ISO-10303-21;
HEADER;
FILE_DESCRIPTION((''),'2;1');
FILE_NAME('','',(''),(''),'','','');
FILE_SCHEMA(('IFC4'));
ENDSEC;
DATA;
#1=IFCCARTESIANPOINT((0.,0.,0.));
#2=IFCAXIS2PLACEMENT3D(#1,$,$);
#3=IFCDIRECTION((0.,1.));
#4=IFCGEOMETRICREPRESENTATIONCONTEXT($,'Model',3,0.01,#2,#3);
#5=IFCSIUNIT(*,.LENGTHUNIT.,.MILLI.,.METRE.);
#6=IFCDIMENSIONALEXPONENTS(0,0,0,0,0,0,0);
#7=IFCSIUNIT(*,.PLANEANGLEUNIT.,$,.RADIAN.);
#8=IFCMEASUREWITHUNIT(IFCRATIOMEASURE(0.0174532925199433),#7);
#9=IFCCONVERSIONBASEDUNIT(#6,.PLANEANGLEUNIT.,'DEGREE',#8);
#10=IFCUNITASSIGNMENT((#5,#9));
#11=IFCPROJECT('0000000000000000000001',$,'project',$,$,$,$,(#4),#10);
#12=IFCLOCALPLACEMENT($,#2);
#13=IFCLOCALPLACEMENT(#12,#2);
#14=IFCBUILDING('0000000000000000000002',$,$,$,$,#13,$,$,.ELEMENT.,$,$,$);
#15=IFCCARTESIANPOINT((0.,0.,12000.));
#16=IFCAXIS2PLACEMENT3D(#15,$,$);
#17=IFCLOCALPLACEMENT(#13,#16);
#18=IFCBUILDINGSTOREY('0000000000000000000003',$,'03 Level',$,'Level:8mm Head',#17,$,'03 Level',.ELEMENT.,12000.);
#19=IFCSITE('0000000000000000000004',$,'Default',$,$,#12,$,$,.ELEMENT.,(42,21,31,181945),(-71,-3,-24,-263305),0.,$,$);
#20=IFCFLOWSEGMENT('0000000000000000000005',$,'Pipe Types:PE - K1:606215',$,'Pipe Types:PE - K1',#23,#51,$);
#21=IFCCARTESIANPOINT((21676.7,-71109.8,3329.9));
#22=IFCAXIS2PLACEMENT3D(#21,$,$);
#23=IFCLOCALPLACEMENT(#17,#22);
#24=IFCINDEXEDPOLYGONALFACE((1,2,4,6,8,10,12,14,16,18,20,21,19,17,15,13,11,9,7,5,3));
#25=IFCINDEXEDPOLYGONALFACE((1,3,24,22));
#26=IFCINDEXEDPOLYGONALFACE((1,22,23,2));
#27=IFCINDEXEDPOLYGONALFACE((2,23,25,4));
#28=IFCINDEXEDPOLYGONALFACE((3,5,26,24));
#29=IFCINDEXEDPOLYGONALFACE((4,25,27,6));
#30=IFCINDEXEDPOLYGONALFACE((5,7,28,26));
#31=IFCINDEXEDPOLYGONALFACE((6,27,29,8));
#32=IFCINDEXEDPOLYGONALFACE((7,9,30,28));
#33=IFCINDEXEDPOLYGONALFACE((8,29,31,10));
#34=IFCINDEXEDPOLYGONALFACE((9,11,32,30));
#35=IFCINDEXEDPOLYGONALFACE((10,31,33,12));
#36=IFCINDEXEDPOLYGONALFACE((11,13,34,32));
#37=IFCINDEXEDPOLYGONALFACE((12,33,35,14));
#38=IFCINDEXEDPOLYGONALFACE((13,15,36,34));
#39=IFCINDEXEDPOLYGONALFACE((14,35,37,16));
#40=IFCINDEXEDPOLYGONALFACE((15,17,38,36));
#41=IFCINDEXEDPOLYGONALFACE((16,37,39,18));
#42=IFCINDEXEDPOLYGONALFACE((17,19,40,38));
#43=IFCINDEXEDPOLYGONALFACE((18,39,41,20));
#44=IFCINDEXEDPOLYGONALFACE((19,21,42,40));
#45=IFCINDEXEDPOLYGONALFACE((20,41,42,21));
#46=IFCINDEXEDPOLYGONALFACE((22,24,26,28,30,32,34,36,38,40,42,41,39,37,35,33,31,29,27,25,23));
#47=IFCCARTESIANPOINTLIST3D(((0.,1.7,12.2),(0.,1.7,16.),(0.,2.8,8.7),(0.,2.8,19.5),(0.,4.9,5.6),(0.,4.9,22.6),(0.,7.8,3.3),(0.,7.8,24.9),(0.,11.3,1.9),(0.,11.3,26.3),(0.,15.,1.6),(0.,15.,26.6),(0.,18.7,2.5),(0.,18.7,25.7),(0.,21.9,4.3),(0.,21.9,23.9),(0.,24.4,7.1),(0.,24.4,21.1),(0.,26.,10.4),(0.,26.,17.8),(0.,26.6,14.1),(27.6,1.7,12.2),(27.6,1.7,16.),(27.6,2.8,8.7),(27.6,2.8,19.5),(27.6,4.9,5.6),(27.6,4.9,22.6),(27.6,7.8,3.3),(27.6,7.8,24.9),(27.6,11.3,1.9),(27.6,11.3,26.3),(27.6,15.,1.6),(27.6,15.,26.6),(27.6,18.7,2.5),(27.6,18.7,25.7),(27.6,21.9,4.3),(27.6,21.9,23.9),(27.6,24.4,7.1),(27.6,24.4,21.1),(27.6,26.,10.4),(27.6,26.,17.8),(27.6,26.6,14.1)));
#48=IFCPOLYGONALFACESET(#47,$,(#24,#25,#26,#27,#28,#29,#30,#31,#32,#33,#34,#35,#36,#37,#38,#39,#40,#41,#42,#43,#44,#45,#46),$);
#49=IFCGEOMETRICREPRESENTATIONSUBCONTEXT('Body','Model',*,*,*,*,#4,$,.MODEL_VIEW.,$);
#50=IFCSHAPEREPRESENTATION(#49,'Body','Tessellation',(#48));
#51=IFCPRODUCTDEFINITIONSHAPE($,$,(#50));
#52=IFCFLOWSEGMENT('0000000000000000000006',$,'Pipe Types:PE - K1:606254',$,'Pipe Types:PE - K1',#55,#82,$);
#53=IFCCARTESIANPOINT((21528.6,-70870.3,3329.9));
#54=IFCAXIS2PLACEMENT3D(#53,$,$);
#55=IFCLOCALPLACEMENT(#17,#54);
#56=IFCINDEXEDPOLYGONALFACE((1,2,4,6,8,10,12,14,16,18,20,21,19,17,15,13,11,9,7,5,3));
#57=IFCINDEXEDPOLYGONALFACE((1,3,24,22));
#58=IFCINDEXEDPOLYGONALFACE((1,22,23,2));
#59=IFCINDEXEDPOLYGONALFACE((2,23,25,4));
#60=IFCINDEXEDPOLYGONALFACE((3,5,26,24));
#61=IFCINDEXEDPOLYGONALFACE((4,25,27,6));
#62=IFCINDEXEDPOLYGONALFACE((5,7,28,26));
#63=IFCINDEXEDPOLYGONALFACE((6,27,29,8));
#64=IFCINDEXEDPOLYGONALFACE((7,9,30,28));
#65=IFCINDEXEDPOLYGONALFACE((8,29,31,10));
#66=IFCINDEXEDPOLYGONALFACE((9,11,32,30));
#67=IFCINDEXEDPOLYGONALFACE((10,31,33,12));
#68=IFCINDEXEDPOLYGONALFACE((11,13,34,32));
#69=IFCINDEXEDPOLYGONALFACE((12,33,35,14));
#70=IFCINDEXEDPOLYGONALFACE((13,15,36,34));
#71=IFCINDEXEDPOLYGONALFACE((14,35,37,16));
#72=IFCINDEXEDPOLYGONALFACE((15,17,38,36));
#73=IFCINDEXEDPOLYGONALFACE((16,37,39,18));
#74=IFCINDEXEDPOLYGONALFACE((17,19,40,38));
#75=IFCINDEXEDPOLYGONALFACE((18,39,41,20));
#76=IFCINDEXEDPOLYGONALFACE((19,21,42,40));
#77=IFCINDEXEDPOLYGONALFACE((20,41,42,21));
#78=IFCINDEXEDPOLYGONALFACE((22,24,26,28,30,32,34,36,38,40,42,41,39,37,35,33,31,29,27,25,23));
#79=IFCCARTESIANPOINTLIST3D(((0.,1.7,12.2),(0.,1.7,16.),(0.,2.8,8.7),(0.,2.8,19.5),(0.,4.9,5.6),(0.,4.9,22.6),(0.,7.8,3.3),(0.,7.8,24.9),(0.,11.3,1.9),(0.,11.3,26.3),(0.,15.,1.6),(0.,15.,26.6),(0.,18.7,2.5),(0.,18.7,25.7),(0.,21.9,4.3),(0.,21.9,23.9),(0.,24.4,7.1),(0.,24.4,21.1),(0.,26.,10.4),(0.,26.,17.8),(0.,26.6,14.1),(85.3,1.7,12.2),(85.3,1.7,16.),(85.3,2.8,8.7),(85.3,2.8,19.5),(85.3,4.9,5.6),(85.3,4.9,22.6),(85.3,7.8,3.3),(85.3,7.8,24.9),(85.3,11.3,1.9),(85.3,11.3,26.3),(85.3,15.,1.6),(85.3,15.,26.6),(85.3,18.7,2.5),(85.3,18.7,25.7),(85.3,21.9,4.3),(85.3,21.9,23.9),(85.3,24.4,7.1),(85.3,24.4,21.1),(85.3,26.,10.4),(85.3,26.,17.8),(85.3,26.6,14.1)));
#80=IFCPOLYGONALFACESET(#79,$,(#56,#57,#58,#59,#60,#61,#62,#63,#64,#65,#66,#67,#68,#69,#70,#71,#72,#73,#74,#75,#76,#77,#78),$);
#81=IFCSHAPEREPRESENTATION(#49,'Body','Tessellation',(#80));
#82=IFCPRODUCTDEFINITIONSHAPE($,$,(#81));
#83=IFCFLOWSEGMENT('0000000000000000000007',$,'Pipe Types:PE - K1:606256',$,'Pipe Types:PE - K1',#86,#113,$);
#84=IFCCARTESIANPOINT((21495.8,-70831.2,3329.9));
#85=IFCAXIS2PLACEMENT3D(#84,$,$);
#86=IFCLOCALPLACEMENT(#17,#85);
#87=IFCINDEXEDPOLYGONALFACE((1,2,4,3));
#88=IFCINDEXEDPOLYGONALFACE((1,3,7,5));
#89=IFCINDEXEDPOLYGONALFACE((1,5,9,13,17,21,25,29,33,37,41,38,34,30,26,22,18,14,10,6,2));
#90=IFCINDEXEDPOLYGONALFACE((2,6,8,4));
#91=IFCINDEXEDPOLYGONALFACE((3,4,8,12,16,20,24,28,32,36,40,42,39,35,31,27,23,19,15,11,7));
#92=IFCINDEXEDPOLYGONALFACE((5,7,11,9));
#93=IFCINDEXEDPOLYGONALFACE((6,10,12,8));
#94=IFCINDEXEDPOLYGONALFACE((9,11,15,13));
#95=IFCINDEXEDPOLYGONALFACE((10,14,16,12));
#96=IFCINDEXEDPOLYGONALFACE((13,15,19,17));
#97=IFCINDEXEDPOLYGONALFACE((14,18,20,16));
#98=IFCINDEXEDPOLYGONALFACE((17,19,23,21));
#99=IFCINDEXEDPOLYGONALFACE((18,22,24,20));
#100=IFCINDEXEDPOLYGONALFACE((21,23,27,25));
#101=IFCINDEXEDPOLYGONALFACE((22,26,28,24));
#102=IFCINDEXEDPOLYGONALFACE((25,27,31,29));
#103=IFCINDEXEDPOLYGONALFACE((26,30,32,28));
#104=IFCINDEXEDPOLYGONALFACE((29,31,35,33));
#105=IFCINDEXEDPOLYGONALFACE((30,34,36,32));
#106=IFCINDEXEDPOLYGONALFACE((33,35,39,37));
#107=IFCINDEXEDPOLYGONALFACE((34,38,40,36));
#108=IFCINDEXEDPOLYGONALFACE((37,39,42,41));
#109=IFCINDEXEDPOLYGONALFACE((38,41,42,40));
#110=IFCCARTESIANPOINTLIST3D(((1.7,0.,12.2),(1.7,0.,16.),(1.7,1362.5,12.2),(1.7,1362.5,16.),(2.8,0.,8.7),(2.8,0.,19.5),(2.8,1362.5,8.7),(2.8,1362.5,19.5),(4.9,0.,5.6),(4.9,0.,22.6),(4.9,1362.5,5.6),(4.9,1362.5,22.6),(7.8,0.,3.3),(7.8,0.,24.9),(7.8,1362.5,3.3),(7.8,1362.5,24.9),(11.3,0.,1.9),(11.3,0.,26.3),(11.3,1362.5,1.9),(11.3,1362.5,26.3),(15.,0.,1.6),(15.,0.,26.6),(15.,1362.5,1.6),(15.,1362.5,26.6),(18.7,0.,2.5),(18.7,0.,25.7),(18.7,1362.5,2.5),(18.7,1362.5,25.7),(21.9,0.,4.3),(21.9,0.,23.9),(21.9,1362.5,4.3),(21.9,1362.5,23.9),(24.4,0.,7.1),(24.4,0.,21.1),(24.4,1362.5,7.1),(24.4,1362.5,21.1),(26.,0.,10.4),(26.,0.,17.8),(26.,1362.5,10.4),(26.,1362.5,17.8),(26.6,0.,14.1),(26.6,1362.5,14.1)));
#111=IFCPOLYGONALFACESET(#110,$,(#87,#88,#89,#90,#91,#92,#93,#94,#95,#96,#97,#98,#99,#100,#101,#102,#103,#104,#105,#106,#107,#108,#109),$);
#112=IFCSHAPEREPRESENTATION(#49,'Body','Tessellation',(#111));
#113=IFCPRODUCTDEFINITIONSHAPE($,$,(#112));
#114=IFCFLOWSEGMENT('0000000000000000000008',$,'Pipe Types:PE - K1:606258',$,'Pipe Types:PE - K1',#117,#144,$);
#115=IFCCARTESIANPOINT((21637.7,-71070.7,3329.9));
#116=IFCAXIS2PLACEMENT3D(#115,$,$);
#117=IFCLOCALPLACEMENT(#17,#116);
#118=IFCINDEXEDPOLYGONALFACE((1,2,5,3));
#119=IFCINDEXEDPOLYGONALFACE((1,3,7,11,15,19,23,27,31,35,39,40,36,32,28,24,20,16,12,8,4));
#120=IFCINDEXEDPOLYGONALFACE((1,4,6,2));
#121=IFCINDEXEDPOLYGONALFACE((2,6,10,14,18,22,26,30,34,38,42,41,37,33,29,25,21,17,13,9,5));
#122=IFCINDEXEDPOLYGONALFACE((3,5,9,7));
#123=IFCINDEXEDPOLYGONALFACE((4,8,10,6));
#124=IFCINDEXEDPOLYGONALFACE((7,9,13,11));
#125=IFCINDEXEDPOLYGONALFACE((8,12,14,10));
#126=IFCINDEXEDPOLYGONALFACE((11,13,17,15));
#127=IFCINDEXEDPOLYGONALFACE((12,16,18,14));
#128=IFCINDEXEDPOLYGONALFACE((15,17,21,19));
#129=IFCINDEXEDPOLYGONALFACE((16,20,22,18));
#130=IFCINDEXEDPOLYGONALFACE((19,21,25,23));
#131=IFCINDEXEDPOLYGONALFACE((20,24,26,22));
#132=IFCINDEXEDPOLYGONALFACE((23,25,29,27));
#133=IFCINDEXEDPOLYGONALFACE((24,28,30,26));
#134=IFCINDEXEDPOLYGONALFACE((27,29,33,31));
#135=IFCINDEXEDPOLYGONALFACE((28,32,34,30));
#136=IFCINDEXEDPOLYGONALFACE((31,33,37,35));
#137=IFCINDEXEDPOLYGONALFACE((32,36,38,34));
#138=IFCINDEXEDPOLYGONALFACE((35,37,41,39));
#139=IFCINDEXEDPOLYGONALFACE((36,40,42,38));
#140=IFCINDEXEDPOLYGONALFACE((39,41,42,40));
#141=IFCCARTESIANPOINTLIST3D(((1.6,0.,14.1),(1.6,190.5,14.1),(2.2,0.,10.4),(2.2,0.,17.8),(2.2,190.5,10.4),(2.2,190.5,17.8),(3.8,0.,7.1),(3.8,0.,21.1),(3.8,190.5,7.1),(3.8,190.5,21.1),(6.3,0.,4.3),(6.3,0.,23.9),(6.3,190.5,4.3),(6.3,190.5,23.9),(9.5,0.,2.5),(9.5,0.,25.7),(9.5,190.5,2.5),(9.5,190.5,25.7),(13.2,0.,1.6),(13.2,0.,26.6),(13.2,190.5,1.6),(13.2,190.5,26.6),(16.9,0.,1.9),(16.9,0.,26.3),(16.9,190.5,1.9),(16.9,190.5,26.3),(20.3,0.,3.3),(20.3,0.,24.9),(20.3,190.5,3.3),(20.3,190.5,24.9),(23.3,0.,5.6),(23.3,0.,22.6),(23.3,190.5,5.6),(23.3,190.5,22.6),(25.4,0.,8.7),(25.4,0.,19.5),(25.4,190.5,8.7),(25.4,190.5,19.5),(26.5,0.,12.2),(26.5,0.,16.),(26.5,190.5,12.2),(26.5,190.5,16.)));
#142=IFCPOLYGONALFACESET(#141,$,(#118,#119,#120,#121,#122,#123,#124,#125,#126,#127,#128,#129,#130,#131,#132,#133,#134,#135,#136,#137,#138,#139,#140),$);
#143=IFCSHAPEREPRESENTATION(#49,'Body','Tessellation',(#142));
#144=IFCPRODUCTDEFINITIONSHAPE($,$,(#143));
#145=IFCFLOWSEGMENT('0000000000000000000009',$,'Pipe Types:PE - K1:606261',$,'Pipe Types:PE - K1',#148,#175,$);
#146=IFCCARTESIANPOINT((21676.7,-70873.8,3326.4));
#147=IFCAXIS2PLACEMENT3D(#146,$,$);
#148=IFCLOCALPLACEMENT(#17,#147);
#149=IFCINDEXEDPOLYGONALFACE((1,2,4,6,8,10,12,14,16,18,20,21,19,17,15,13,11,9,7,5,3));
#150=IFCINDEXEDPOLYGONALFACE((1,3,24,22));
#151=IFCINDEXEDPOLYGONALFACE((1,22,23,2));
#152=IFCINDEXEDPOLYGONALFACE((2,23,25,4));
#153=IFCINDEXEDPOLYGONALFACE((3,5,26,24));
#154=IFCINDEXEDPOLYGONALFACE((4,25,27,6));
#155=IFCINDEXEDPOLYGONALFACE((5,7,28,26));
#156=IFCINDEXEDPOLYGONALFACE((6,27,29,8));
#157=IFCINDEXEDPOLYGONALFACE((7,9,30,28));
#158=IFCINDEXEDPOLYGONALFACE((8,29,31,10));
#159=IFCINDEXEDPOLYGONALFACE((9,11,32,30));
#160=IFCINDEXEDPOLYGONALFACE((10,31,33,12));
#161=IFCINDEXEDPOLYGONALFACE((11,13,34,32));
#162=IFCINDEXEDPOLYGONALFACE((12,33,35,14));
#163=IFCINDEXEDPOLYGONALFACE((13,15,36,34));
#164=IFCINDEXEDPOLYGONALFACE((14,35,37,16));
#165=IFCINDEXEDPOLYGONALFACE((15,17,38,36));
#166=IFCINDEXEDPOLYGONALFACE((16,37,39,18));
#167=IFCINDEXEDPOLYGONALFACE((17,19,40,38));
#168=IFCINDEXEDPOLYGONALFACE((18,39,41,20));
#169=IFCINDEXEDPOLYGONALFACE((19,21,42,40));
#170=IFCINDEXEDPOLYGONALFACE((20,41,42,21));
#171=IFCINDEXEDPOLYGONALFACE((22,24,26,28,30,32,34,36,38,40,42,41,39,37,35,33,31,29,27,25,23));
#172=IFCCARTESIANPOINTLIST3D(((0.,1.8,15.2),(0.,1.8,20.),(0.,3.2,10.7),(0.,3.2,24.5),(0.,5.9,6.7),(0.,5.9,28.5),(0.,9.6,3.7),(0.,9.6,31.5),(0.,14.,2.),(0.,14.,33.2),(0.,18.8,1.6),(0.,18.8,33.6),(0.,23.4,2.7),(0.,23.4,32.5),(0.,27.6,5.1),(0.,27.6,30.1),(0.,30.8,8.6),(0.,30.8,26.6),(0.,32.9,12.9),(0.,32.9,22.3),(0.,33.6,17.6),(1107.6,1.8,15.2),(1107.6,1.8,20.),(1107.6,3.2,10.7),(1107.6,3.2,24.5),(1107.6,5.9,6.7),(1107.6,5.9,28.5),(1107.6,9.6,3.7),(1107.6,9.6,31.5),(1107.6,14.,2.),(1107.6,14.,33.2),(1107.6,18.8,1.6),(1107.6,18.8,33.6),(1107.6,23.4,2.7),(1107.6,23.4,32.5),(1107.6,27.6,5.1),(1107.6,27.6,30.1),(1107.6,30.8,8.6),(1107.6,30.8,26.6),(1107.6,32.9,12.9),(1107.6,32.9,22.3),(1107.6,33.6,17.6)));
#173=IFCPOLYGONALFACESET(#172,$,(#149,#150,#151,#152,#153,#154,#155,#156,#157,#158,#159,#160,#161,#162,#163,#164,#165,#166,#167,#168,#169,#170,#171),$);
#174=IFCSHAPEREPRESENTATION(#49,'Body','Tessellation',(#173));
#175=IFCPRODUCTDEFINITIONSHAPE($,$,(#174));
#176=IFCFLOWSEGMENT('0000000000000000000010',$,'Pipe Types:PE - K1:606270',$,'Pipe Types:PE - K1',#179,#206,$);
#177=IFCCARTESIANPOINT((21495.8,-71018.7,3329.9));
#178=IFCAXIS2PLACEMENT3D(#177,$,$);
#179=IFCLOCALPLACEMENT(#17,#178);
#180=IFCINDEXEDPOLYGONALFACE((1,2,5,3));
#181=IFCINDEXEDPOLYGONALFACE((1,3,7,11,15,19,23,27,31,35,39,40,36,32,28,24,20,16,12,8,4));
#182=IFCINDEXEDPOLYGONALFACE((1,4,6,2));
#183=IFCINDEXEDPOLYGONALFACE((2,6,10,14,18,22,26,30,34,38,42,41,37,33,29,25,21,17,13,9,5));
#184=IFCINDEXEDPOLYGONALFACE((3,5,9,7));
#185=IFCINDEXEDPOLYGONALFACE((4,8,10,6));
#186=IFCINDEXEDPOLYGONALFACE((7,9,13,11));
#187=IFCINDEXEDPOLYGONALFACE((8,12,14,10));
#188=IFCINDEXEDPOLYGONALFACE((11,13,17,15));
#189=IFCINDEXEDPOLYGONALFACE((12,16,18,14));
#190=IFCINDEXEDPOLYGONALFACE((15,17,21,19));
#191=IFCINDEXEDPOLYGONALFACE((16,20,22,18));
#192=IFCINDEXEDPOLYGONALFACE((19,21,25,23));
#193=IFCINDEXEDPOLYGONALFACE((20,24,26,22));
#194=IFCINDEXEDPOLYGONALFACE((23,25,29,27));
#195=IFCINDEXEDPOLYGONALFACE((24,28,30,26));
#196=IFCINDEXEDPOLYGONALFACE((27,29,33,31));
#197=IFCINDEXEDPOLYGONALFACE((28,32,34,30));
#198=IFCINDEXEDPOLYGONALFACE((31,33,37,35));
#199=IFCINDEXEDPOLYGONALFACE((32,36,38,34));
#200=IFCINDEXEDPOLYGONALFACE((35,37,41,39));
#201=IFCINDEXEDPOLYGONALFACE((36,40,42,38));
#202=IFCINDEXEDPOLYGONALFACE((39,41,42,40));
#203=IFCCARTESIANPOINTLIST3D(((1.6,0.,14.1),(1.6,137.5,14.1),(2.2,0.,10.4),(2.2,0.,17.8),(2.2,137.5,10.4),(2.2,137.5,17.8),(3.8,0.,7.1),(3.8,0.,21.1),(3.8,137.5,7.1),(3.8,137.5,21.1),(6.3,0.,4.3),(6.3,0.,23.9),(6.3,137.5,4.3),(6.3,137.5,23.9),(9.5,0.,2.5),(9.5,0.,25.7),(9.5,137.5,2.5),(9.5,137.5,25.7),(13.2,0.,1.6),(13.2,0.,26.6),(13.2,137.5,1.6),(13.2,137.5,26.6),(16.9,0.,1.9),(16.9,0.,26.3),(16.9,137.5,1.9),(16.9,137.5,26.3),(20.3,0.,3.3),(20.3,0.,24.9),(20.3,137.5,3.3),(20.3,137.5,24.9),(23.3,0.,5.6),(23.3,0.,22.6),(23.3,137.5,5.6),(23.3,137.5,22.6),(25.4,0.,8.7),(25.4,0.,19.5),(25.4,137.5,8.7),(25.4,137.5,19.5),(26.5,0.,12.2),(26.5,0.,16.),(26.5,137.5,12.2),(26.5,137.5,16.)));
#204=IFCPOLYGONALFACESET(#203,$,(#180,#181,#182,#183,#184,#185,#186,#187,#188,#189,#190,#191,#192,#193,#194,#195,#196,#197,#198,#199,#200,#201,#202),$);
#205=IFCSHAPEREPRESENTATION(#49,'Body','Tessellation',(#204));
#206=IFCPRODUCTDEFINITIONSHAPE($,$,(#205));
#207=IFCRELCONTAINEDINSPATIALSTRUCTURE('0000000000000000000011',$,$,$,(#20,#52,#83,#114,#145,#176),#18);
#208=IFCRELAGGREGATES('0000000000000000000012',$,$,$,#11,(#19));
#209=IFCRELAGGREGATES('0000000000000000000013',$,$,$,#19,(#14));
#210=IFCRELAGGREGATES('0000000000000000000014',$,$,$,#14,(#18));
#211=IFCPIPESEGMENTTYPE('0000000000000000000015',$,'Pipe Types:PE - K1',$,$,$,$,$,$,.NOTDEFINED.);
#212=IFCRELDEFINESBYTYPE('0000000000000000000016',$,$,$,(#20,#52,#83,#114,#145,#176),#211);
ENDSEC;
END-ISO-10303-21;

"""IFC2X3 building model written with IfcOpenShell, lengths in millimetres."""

from ifc_helpers import new_model, entity, si_unit, converted_unit, direction, frame, frame_2d, origin, origin_2d_with_axis, place, context, subcontext, project, spatial, circle, extrude, type_object, element, save


model = new_model("IFC2X3")

# Units and contexts
model_context = context("Model", 3, precision=0.01, world=origin(), true_north=direction((0.0, 1.0)))
body_context = subcontext(model_context, "Body", "Model", "MODEL_VIEW")
ifc_project = project(units=[si_unit("LENGTHUNIT", "METRE", prefix="MILLI"), converted_unit("PLANEANGLEUNIT", "DEGREE", entity("IfcRatioMeasure", 0.0174532925199433), si_unit("PLANEANGLEUNIT", "RADIAN"), dimensions=[0, 0, 0, 0, 0, 0, 0])], contexts=[model_context])

# Site, building, storey
site_placement = place(None, origin())
site = spatial("IfcSite", under=ifc_project, at=site_placement, Name="Default", CompositionType="ELEMENT", RefLatitude=(42, 21, 31, 181945), RefLongitude=(-71, -3, -24, -263305), RefElevation=0.0)
building_placement = place(site_placement, origin())
building = spatial("IfcBuilding", under=site, at=building_placement, CompositionType="ELEMENT")
storey_placement = place(building_placement, frame((0.0, 0.0, 12000.0)))
storey = spatial("IfcBuildingStorey", under=building, at=storey_placement, Name="03 Level", ObjectType="Level:8mm Head", LongName="03 Level", CompositionType="ELEMENT", Elevation=12000.0)

# Flow segments
pipe_segment_type = type_object("IfcPipeSegmentType", Name="Pipe Types:PE - K1", PredefinedType="NOTDEFINED")
flow_segment_1_placement = place(storey_placement, frame((21676.7, -71109.8, 3329.9)))
element("IfcFlowSegment", 1, at=flow_segment_1_placement, inside=storey, type_object=pipe_segment_type, Name="Pipe Types:PE - K1:606215", ObjectType="Pipe Types:PE - K1", context=body_context, shape_type="SweptSolid", body=[
    extrude(circle(Radius=12.5, at=frame_2d((0.0, 0.0), x_axis=(1.0, 0.0))), frame((0.0, 14.1, 14.1), z_axis=(1.0, 0.0, 0.0), x_axis=(0.0, 1.0, 0.0)), (0.0, 0.0, 1.0), 27.6),
])
flow_segment_2_placement = place(storey_placement, frame((21528.6, -70870.3, 3329.9)))
element("IfcFlowSegment", 2, at=flow_segment_2_placement, inside=storey, type_object=pipe_segment_type, Name="Pipe Types:PE - K1:606254", ObjectType="Pipe Types:PE - K1", context=body_context, shape_type="SweptSolid", body=[
    extrude(circle(Radius=12.5, at=frame_2d((0.0, 0.0), x_axis=(1.0, 0.0))), frame((0.0, 14.1, 14.1), z_axis=(1.0, 0.0, 0.0), x_axis=(0.0, 1.0, 0.0)), (0.0, 0.0, 1.0), 85.3),
])
flow_segment_3_placement = place(storey_placement, frame((21495.8, -70831.2, 3329.9)))
element("IfcFlowSegment", 3, at=flow_segment_3_placement, inside=storey, type_object=pipe_segment_type, Name="Pipe Types:PE - K1:606256", ObjectType="Pipe Types:PE - K1", context=body_context, shape_type="SweptSolid", body=[
    extrude(circle(Radius=12.5, at=frame_2d((0.0, 0.0), x_axis=(1.0, 0.0))), frame((14.1, 0.0, 14.1), z_axis=(0.0, 1.0, 0.0), x_axis=(1.0, 0.0, 0.0)), (0.0, 0.0, 1.0), 1362.5),
])
flow_segment_4_placement = place(storey_placement, frame((21637.7, -71070.7, 3329.9)))
element("IfcFlowSegment", 4, at=flow_segment_4_placement, inside=storey, type_object=pipe_segment_type, Name="Pipe Types:PE - K1:606258", ObjectType="Pipe Types:PE - K1", context=body_context, shape_type="SweptSolid", body=[
    extrude(circle(Radius=12.5, at=frame_2d((0.0, 0.0), x_axis=(1.0, 0.0))), frame((14.1, 0.0, 14.1), z_axis=(0.0, 1.0, 0.0), x_axis=(-1.0, 0.0, 0.0)), (0.0, 0.0, 1.0), 190.5),
])
flow_segment_5_placement = place(storey_placement, frame((21676.7, -70873.8, 3326.4)))
element("IfcFlowSegment", 5, at=flow_segment_5_placement, inside=storey, type_object=pipe_segment_type, Name="Pipe Types:PE - K1:606261", ObjectType="Pipe Types:PE - K1", context=body_context, shape_type="SweptSolid", body=[
    extrude(circle(Radius=16.0, at=origin_2d_with_axis()), frame((0.0, 17.6, 17.6), z_axis=(1.0, 0.0, 0.0), x_axis=(0.0, 1.0, 0.0)), (0.0, 0.0, 1.0), 1107.6),
])
flow_segment_6_placement = place(storey_placement, frame((21495.8, -71018.7, 3329.9)))
element("IfcFlowSegment", 6, at=flow_segment_6_placement, inside=storey, type_object=pipe_segment_type, Name="Pipe Types:PE - K1:606270", ObjectType="Pipe Types:PE - K1", context=body_context, shape_type="SweptSolid", body=[
    extrude(circle(Radius=12.5, at=origin_2d_with_axis()), frame((14.1, 0.0, 14.1), z_axis=(0.0, 1.0, 0.0), x_axis=(-1.0, 0.0, 0.0)), (0.0, 0.0, 1.0), 137.5),
])

save(model, "model.ifc")
